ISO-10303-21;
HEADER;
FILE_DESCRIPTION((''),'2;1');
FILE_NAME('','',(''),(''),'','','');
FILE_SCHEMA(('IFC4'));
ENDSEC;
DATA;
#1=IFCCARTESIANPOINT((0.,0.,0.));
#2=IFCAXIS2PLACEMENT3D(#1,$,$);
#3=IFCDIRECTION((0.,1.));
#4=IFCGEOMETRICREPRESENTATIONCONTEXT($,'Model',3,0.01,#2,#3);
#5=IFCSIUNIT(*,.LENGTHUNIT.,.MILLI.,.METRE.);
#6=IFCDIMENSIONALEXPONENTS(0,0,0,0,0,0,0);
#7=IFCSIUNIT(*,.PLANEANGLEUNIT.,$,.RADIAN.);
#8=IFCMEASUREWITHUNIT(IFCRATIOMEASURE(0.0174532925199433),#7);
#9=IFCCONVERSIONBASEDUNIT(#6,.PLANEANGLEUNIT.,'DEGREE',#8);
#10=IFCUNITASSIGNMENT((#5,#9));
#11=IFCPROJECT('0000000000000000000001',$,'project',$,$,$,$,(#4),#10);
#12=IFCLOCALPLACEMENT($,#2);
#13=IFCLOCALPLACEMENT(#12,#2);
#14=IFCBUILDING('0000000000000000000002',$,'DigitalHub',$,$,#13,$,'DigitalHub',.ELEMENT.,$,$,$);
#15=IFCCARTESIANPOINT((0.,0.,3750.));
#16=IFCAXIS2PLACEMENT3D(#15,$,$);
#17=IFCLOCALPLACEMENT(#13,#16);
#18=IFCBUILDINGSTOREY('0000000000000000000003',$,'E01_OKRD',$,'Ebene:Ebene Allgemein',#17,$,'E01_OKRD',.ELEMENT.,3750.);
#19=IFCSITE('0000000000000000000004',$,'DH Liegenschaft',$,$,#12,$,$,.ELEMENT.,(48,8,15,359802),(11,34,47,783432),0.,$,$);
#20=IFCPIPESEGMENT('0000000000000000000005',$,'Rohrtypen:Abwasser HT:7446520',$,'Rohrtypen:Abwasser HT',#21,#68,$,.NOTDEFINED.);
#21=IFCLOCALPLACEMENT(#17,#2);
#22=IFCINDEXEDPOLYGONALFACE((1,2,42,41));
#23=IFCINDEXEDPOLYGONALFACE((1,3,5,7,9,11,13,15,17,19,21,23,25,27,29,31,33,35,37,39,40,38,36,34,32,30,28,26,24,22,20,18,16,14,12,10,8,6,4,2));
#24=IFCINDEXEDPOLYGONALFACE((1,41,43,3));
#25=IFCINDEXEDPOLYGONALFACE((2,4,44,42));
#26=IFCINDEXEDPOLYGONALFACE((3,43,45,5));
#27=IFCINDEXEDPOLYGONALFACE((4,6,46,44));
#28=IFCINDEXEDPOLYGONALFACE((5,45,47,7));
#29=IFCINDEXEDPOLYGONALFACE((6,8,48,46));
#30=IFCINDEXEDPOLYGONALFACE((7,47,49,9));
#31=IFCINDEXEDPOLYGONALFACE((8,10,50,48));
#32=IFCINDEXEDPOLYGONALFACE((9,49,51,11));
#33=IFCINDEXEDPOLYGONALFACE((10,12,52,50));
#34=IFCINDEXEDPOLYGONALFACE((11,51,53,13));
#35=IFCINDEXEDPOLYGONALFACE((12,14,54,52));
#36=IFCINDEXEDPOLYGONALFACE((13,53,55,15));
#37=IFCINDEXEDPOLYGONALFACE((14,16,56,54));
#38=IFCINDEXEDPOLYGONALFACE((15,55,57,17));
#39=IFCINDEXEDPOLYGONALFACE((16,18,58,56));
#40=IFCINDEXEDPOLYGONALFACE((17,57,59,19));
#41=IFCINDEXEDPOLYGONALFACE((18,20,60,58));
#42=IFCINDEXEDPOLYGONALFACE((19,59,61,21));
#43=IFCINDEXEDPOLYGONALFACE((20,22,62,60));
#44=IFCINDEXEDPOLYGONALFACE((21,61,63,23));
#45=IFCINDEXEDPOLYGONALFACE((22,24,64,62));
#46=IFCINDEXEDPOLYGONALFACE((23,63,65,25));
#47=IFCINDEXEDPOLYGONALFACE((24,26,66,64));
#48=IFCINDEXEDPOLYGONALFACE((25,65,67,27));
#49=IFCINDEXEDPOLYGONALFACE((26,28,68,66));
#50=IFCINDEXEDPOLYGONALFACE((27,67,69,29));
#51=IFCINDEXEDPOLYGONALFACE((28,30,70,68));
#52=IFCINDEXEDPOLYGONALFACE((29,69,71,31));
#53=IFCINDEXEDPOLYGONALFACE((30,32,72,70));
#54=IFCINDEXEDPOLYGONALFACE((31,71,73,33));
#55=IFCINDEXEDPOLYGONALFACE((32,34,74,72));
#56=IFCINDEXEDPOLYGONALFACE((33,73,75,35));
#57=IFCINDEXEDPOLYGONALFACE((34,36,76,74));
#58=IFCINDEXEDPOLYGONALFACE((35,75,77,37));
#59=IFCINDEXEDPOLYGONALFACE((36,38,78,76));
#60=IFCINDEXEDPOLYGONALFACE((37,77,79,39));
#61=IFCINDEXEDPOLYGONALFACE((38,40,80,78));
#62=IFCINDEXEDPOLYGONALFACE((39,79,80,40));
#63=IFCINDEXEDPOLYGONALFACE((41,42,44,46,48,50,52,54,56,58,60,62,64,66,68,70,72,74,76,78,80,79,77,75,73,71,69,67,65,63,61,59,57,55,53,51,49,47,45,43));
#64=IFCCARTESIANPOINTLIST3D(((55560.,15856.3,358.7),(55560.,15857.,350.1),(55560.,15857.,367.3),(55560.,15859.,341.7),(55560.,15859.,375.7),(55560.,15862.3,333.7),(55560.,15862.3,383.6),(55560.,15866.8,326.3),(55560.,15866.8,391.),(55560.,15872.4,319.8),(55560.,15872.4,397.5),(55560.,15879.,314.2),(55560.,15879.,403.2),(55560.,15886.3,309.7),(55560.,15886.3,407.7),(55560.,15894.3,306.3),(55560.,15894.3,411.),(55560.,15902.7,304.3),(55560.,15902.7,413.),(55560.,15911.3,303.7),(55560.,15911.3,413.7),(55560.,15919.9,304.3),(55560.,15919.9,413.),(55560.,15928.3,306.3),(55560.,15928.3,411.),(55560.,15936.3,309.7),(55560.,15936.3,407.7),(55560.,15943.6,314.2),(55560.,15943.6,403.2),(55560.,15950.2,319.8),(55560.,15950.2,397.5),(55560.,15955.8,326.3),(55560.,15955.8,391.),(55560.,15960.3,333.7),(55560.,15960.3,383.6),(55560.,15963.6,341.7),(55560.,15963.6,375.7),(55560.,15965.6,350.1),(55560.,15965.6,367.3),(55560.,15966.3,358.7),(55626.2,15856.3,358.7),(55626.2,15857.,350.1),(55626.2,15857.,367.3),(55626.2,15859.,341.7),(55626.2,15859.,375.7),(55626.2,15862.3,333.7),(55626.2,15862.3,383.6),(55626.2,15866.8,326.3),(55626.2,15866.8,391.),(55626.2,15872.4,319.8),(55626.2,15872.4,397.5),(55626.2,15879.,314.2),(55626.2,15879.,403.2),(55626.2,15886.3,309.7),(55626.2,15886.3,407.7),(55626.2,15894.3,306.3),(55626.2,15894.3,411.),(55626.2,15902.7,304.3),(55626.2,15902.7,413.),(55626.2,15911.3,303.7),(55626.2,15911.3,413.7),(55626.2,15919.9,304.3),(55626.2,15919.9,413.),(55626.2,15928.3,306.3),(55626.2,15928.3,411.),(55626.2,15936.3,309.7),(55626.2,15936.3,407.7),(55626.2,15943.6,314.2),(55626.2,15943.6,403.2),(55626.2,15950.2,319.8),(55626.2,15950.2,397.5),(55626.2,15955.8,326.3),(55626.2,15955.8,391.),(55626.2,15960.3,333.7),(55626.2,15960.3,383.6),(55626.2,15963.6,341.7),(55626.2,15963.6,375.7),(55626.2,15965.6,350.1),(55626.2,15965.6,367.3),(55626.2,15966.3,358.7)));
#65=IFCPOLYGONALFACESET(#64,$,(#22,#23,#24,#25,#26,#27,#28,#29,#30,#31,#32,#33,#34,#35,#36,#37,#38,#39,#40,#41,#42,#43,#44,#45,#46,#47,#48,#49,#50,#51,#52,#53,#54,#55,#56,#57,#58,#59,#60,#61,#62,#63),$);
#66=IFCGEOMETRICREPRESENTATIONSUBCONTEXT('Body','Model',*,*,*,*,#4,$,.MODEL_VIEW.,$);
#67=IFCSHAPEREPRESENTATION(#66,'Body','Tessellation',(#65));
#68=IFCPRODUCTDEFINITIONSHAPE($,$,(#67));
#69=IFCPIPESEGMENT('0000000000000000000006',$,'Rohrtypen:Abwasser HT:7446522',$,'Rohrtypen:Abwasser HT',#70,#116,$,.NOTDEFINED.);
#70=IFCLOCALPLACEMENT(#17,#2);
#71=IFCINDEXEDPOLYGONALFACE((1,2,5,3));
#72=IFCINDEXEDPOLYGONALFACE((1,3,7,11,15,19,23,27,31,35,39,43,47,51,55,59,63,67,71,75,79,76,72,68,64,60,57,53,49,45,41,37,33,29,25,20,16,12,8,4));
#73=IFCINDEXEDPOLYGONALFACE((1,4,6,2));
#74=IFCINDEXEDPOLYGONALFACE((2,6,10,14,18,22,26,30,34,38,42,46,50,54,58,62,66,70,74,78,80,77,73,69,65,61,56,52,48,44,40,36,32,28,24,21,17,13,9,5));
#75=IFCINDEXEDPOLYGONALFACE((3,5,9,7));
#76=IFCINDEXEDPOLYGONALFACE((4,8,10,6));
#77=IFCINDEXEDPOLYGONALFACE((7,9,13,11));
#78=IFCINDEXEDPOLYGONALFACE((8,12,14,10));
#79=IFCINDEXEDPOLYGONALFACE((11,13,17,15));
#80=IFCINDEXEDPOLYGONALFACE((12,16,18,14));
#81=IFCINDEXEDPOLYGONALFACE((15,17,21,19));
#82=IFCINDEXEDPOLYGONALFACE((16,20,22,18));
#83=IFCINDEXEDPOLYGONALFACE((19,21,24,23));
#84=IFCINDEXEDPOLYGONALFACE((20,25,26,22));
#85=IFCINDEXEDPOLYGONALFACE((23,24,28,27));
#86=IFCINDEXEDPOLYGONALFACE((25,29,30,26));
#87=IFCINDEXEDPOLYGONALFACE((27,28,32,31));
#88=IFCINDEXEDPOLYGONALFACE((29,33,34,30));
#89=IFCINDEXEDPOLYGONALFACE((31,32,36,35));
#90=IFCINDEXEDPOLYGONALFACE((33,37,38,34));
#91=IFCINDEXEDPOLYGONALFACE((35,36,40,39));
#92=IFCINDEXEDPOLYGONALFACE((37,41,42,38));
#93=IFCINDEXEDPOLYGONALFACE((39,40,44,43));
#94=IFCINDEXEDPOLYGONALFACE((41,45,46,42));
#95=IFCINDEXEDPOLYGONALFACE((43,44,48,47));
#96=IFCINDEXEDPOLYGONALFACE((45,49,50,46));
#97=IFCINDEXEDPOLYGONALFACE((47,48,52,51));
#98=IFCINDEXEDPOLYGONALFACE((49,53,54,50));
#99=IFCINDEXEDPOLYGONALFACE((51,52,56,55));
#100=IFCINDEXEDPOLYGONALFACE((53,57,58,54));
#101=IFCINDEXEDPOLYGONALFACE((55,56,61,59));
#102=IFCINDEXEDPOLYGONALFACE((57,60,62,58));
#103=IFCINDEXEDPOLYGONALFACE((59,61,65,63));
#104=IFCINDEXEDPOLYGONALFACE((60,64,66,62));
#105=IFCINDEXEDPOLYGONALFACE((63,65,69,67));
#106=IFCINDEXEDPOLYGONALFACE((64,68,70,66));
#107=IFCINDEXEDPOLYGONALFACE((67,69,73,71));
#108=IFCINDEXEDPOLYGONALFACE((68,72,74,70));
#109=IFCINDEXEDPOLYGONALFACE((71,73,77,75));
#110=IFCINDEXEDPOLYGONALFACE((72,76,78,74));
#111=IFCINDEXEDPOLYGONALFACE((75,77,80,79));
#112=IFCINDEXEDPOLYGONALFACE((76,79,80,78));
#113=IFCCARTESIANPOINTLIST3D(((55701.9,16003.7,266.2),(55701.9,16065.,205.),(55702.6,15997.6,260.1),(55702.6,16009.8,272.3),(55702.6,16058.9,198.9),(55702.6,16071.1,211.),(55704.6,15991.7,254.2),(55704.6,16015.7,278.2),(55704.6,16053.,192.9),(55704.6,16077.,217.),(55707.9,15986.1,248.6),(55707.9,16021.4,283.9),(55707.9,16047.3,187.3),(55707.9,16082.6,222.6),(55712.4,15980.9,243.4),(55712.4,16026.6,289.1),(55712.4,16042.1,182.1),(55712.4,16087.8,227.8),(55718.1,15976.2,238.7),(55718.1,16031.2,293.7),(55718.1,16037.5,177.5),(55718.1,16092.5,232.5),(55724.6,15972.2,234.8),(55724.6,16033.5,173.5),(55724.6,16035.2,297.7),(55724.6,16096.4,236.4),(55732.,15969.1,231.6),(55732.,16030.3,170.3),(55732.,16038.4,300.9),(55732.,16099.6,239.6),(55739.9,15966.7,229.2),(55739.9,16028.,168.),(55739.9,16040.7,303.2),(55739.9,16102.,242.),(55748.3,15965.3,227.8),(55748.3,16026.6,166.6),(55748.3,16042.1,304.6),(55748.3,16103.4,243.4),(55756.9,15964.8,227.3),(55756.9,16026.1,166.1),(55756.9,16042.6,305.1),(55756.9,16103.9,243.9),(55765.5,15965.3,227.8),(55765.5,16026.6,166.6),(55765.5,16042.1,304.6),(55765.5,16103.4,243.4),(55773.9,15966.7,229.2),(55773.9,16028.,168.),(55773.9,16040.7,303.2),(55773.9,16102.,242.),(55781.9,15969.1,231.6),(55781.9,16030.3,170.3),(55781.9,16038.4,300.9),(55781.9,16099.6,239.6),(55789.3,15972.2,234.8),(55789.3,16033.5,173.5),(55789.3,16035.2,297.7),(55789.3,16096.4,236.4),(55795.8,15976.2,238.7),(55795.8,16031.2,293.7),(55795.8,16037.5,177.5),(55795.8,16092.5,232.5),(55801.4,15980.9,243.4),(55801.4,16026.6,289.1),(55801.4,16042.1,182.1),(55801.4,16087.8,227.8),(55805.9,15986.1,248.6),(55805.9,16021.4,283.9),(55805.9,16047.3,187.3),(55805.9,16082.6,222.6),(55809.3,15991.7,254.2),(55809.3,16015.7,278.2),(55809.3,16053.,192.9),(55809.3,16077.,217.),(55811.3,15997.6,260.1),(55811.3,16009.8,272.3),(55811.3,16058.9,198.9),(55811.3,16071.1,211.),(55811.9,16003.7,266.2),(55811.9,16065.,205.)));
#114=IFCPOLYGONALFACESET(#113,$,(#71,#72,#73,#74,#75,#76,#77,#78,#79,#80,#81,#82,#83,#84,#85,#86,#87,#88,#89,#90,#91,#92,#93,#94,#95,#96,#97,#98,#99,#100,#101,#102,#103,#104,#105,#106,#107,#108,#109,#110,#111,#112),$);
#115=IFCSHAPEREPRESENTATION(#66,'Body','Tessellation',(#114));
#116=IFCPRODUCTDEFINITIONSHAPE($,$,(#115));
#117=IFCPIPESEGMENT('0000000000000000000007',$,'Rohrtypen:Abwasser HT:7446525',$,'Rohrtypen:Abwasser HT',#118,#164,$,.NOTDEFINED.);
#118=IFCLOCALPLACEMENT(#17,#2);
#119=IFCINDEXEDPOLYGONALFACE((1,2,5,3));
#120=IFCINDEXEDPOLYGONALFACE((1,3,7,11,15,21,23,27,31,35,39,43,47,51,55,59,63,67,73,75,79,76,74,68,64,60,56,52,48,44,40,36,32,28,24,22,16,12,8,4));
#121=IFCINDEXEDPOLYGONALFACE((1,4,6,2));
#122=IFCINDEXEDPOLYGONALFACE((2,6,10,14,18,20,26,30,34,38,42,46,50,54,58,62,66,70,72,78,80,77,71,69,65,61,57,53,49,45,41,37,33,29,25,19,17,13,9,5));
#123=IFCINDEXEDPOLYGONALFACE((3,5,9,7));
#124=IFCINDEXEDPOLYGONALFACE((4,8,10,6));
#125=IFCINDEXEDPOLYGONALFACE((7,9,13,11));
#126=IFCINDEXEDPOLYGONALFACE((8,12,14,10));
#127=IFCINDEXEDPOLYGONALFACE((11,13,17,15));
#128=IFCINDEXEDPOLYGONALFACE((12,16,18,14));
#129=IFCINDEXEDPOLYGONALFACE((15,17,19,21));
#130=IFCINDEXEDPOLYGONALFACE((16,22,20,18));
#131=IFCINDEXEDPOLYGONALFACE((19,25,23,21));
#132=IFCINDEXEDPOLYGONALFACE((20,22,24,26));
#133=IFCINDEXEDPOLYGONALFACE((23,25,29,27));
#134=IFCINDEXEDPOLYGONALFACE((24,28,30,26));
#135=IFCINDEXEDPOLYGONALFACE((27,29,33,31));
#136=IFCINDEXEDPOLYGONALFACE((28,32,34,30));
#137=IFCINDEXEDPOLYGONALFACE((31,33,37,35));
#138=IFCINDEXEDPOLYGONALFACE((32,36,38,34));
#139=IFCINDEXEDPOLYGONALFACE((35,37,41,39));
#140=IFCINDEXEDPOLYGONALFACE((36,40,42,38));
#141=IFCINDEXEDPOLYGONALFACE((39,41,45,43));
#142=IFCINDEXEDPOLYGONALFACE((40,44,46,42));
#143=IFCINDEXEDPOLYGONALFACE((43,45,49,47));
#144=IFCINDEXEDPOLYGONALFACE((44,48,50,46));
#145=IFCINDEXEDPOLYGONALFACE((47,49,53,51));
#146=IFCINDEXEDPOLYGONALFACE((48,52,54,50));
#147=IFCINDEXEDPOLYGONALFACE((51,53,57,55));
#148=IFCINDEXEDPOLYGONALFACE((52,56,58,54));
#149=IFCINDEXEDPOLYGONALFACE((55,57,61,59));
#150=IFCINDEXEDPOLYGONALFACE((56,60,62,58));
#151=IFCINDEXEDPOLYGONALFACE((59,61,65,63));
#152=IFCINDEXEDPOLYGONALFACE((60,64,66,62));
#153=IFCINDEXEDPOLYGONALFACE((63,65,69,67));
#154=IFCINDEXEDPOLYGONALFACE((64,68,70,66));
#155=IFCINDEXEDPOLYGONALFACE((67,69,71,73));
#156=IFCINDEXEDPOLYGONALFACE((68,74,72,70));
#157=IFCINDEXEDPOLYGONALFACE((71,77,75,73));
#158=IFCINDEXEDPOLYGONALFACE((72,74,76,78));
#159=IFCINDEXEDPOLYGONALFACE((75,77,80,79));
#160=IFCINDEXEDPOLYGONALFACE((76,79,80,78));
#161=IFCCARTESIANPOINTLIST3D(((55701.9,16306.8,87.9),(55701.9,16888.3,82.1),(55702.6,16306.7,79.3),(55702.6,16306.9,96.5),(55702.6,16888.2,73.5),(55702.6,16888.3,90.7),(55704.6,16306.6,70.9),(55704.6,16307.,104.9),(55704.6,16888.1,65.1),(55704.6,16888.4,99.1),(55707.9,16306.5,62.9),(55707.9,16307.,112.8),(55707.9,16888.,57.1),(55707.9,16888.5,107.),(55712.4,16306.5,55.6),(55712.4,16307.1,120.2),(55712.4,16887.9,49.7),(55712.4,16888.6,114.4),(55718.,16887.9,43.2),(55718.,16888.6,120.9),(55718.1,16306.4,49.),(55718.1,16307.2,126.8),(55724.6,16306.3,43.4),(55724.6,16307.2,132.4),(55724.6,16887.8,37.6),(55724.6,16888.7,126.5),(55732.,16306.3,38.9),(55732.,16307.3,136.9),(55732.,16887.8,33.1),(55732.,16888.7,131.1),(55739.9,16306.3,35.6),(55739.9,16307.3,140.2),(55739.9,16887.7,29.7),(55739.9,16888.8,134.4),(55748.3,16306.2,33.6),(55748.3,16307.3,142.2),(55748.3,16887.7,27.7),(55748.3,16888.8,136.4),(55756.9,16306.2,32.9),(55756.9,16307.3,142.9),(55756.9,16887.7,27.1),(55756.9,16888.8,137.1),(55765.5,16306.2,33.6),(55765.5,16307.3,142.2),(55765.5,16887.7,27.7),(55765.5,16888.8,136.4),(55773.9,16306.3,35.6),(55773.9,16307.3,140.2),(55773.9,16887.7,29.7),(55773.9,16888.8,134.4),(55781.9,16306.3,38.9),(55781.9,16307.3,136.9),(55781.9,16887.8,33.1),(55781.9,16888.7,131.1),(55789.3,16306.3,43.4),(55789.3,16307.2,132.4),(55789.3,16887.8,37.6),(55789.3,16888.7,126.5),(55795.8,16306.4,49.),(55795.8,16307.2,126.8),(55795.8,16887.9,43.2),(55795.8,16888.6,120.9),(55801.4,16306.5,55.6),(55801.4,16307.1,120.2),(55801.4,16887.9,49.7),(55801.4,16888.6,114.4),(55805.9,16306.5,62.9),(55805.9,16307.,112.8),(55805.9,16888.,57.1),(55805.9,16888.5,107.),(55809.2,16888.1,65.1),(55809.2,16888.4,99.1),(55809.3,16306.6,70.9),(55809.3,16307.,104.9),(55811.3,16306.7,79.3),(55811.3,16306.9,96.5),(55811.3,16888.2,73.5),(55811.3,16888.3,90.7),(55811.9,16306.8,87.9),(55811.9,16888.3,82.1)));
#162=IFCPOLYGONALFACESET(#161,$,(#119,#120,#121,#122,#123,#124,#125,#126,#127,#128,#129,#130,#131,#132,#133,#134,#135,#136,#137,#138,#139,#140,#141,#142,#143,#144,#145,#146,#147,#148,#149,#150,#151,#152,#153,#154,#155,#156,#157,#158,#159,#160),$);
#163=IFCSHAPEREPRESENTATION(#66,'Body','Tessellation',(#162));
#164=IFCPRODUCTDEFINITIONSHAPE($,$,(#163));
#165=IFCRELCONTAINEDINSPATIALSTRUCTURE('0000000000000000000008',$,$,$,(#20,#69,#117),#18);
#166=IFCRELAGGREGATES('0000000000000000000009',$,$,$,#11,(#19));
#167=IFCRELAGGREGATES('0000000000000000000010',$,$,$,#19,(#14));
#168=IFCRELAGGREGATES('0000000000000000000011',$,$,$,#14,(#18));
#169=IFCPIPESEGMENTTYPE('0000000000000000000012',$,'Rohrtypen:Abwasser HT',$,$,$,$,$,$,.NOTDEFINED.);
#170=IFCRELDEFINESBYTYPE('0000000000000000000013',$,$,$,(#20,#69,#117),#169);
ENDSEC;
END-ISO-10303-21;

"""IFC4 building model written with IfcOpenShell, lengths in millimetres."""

from ifc_helpers import new_model, entity, si_unit, converted_unit, direction, frame, origin, place, context, subcontext, project, spatial, indexed_curve, outline, extrude, type_object, element, save


model = new_model("IFC4")

# Units and contexts
model_context = context("Model", 3, precision=0.01, world=origin(), true_north=direction((0.0, 1.0)))
body_context = subcontext(model_context, "Body", "Model", "MODEL_VIEW")
ifc_project = project(units=[si_unit("LENGTHUNIT", "METRE", prefix="MILLI"), converted_unit("PLANEANGLEUNIT", "DEGREE", entity("IfcRatioMeasure", 0.0174532925199433), si_unit("PLANEANGLEUNIT", "RADIAN"), dimensions=[0, 0, 0, 0, 0, 0, 0])], contexts=[model_context])

# Site, building, storey
site_placement = place(None, origin())
site = spatial("IfcSite", under=ifc_project, at=site_placement, Name="DH Liegenschaft", CompositionType="ELEMENT", RefLatitude=(48, 8, 15, 359802), RefLongitude=(11, 34, 47, 783432), RefElevation=0.0)
building_placement = place(site_placement, origin())
building = spatial("IfcBuilding", under=site, at=building_placement, Name="DigitalHub", LongName="DigitalHub", CompositionType="ELEMENT")
storey_placement = place(building_placement, frame((0.0, 0.0, 3750.0)))
storey = spatial("IfcBuildingStorey", under=building, at=storey_placement, Name="E01_OKRD", ObjectType="Ebene:Ebene Allgemein", LongName="E01_OKRD", CompositionType="ELEMENT", Elevation=3750.0)

# Pipe segments
pipe_segment_type_1 = type_object("IfcPipeSegmentType", Name="Rohrtypen:Abwasser HT", PredefinedType="NOTDEFINED")
pipe_segment_1_placement = place(storey_placement, frame((55560.0, 15854.7, 302.1)))
element("IfcPipeSegment", 1, at=pipe_segment_1_placement, inside=storey, type_object=pipe_segment_type_1, Name="Rohrtypen:Abwasser HT:7446520", ObjectType="Rohrtypen:Abwasser HT", PredefinedType="NOTDEFINED", context=body_context, shape_type="SweptSolid", body=[
    extrude(outline(indexed_curve([(55.0, 0.0), (54.3, 8.6), (52.3, 17.0), (49.0, 25.0), (44.5, 32.3), (38.9, 38.9), (32.3, 44.5), (25.0, 49.0), (17.0, 52.3), (8.6, 54.3), (0.0, 55.0), (-8.6, 54.3), (-17.0, 52.3), (-25.0, 49.0), (-32.3, 44.5), (-38.9, 38.9), (-44.5, 32.3), (-49.0, 25.0), (-52.3, 17.0), (-54.3, 8.6), (-55.0, 0.0), (-54.3, -8.6), (-52.3, -17.0), (-49.0, -25.0), (-44.5, -32.3), (-38.9, -38.9), (-32.3, -44.5), (-25.0, -49.0), (-17.0, -52.3), (-8.6, -54.3), (0.0, -55.0), (8.6, -54.3), (17.0, -52.3), (25.0, -49.0), (32.3, -44.5), (38.9, -38.9), (44.5, -32.3), (49.0, -25.0), (52.3, -17.0), (54.3, -8.6), (55.0, 0.0)], self_intersect=False)), frame((0.0, 56.6, 56.6), z_axis=(1.0, 0.0, 0.0), x_axis=(0.0, -1.0, -0.000001)), (0.0, 0.0, 1.0), 66.3),
])
pipe_segment_2_placement = place(storey_placement, frame((55700.3, 15963.2, 164.5)))
element("IfcPipeSegment", 2, at=pipe_segment_2_placement, inside=storey, type_object=pipe_segment_type_1, Name="Rohrtypen:Abwasser HT:7446522", ObjectType="Rohrtypen:Abwasser HT", PredefinedType="NOTDEFINED", context=body_context, shape_type="SweptSolid", body=[
    extrude(outline(indexed_curve([(55.0, 0.0), (54.3, 8.6), (52.3, 17.0), (49.0, 25.0), (44.5, 32.3), (38.9, 38.9), (32.3, 44.5), (25.0, 49.0), (17.0, 52.3), (8.6, 54.3), (0.0, 55.0), (-8.6, 54.3), (-17.0, 52.3), (-25.0, 49.0), (-32.3, 44.5), (-38.9, 38.9), (-44.5, 32.3), (-49.0, 25.0), (-52.3, 17.0), (-54.3, 8.6), (-55.0, 0.0), (-54.3, -8.6), (-52.3, -17.0), (-49.0, -25.0), (-44.5, -32.3), (-38.9, -38.9), (-32.3, -44.5), (-25.0, -49.0), (-17.0, -52.3), (-8.6, -54.3), (0.0, -55.0), (8.6, -54.3), (17.0, -52.3), (25.0, -49.0), (32.3, -44.5), (38.9, -38.9), (44.5, -32.3), (49.0, -25.0), (52.3, -17.0), (54.3, -8.6), (55.0, 0.0)], self_intersect=False)), frame((56.6, 40.5, 101.8), z_axis=(0.0, 0.707107, -0.707107), x_axis=(-1.0, 0.0, 0.0)), (0.0, 0.0, 1.0), 86.6),
])
pipe_segment_3_placement = place(storey_placement, frame((55700.3, 16304.6, 25.5)))
element("IfcPipeSegment", 3, at=pipe_segment_3_placement, inside=storey, type_object=pipe_segment_type_1, Name="Rohrtypen:Abwasser HT:7446525", ObjectType="Rohrtypen:Abwasser HT", PredefinedType="NOTDEFINED", context=body_context, shape_type="SweptSolid", body=[
    extrude(outline(indexed_curve([(55.0, 0.0), (54.3, 8.6), (52.3, 17.0), (49.0, 25.0), (44.5, 32.3), (38.9, 38.9), (32.3, 44.5), (25.0, 49.0), (17.0, 52.3), (8.6, 54.3), (0.0, 55.0), (-8.6, 54.3), (-17.0, 52.3), (-25.0, 49.0), (-32.3, 44.5), (-38.9, 38.9), (-44.5, 32.3), (-49.0, 25.0), (-52.3, 17.0), (-54.3, 8.6), (-55.0, 0.0), (-54.3, -8.6), (-52.3, -17.0), (-49.0, -25.0), (-44.5, -32.3), (-38.9, -38.9), (-32.3, -44.5), (-25.0, -49.0), (-17.0, -52.3), (-8.6, -54.3), (0.0, -55.0), (8.6, -54.3), (17.0, -52.3), (25.0, -49.0), (32.3, -44.5), (38.9, -38.9), (44.5, -32.3), (49.0, -25.0), (52.3, -17.0), (54.3, -8.6), (55.0, 0.0)], self_intersect=False)), frame((56.6, 583.6, 56.6), z_axis=(0.000006, -0.99995, 0.010016), x_axis=(-1.0, -0.000006, 0.0)), (0.0, 0.0, 1.0), 581.5),
])

save(model, "model.ifc")
